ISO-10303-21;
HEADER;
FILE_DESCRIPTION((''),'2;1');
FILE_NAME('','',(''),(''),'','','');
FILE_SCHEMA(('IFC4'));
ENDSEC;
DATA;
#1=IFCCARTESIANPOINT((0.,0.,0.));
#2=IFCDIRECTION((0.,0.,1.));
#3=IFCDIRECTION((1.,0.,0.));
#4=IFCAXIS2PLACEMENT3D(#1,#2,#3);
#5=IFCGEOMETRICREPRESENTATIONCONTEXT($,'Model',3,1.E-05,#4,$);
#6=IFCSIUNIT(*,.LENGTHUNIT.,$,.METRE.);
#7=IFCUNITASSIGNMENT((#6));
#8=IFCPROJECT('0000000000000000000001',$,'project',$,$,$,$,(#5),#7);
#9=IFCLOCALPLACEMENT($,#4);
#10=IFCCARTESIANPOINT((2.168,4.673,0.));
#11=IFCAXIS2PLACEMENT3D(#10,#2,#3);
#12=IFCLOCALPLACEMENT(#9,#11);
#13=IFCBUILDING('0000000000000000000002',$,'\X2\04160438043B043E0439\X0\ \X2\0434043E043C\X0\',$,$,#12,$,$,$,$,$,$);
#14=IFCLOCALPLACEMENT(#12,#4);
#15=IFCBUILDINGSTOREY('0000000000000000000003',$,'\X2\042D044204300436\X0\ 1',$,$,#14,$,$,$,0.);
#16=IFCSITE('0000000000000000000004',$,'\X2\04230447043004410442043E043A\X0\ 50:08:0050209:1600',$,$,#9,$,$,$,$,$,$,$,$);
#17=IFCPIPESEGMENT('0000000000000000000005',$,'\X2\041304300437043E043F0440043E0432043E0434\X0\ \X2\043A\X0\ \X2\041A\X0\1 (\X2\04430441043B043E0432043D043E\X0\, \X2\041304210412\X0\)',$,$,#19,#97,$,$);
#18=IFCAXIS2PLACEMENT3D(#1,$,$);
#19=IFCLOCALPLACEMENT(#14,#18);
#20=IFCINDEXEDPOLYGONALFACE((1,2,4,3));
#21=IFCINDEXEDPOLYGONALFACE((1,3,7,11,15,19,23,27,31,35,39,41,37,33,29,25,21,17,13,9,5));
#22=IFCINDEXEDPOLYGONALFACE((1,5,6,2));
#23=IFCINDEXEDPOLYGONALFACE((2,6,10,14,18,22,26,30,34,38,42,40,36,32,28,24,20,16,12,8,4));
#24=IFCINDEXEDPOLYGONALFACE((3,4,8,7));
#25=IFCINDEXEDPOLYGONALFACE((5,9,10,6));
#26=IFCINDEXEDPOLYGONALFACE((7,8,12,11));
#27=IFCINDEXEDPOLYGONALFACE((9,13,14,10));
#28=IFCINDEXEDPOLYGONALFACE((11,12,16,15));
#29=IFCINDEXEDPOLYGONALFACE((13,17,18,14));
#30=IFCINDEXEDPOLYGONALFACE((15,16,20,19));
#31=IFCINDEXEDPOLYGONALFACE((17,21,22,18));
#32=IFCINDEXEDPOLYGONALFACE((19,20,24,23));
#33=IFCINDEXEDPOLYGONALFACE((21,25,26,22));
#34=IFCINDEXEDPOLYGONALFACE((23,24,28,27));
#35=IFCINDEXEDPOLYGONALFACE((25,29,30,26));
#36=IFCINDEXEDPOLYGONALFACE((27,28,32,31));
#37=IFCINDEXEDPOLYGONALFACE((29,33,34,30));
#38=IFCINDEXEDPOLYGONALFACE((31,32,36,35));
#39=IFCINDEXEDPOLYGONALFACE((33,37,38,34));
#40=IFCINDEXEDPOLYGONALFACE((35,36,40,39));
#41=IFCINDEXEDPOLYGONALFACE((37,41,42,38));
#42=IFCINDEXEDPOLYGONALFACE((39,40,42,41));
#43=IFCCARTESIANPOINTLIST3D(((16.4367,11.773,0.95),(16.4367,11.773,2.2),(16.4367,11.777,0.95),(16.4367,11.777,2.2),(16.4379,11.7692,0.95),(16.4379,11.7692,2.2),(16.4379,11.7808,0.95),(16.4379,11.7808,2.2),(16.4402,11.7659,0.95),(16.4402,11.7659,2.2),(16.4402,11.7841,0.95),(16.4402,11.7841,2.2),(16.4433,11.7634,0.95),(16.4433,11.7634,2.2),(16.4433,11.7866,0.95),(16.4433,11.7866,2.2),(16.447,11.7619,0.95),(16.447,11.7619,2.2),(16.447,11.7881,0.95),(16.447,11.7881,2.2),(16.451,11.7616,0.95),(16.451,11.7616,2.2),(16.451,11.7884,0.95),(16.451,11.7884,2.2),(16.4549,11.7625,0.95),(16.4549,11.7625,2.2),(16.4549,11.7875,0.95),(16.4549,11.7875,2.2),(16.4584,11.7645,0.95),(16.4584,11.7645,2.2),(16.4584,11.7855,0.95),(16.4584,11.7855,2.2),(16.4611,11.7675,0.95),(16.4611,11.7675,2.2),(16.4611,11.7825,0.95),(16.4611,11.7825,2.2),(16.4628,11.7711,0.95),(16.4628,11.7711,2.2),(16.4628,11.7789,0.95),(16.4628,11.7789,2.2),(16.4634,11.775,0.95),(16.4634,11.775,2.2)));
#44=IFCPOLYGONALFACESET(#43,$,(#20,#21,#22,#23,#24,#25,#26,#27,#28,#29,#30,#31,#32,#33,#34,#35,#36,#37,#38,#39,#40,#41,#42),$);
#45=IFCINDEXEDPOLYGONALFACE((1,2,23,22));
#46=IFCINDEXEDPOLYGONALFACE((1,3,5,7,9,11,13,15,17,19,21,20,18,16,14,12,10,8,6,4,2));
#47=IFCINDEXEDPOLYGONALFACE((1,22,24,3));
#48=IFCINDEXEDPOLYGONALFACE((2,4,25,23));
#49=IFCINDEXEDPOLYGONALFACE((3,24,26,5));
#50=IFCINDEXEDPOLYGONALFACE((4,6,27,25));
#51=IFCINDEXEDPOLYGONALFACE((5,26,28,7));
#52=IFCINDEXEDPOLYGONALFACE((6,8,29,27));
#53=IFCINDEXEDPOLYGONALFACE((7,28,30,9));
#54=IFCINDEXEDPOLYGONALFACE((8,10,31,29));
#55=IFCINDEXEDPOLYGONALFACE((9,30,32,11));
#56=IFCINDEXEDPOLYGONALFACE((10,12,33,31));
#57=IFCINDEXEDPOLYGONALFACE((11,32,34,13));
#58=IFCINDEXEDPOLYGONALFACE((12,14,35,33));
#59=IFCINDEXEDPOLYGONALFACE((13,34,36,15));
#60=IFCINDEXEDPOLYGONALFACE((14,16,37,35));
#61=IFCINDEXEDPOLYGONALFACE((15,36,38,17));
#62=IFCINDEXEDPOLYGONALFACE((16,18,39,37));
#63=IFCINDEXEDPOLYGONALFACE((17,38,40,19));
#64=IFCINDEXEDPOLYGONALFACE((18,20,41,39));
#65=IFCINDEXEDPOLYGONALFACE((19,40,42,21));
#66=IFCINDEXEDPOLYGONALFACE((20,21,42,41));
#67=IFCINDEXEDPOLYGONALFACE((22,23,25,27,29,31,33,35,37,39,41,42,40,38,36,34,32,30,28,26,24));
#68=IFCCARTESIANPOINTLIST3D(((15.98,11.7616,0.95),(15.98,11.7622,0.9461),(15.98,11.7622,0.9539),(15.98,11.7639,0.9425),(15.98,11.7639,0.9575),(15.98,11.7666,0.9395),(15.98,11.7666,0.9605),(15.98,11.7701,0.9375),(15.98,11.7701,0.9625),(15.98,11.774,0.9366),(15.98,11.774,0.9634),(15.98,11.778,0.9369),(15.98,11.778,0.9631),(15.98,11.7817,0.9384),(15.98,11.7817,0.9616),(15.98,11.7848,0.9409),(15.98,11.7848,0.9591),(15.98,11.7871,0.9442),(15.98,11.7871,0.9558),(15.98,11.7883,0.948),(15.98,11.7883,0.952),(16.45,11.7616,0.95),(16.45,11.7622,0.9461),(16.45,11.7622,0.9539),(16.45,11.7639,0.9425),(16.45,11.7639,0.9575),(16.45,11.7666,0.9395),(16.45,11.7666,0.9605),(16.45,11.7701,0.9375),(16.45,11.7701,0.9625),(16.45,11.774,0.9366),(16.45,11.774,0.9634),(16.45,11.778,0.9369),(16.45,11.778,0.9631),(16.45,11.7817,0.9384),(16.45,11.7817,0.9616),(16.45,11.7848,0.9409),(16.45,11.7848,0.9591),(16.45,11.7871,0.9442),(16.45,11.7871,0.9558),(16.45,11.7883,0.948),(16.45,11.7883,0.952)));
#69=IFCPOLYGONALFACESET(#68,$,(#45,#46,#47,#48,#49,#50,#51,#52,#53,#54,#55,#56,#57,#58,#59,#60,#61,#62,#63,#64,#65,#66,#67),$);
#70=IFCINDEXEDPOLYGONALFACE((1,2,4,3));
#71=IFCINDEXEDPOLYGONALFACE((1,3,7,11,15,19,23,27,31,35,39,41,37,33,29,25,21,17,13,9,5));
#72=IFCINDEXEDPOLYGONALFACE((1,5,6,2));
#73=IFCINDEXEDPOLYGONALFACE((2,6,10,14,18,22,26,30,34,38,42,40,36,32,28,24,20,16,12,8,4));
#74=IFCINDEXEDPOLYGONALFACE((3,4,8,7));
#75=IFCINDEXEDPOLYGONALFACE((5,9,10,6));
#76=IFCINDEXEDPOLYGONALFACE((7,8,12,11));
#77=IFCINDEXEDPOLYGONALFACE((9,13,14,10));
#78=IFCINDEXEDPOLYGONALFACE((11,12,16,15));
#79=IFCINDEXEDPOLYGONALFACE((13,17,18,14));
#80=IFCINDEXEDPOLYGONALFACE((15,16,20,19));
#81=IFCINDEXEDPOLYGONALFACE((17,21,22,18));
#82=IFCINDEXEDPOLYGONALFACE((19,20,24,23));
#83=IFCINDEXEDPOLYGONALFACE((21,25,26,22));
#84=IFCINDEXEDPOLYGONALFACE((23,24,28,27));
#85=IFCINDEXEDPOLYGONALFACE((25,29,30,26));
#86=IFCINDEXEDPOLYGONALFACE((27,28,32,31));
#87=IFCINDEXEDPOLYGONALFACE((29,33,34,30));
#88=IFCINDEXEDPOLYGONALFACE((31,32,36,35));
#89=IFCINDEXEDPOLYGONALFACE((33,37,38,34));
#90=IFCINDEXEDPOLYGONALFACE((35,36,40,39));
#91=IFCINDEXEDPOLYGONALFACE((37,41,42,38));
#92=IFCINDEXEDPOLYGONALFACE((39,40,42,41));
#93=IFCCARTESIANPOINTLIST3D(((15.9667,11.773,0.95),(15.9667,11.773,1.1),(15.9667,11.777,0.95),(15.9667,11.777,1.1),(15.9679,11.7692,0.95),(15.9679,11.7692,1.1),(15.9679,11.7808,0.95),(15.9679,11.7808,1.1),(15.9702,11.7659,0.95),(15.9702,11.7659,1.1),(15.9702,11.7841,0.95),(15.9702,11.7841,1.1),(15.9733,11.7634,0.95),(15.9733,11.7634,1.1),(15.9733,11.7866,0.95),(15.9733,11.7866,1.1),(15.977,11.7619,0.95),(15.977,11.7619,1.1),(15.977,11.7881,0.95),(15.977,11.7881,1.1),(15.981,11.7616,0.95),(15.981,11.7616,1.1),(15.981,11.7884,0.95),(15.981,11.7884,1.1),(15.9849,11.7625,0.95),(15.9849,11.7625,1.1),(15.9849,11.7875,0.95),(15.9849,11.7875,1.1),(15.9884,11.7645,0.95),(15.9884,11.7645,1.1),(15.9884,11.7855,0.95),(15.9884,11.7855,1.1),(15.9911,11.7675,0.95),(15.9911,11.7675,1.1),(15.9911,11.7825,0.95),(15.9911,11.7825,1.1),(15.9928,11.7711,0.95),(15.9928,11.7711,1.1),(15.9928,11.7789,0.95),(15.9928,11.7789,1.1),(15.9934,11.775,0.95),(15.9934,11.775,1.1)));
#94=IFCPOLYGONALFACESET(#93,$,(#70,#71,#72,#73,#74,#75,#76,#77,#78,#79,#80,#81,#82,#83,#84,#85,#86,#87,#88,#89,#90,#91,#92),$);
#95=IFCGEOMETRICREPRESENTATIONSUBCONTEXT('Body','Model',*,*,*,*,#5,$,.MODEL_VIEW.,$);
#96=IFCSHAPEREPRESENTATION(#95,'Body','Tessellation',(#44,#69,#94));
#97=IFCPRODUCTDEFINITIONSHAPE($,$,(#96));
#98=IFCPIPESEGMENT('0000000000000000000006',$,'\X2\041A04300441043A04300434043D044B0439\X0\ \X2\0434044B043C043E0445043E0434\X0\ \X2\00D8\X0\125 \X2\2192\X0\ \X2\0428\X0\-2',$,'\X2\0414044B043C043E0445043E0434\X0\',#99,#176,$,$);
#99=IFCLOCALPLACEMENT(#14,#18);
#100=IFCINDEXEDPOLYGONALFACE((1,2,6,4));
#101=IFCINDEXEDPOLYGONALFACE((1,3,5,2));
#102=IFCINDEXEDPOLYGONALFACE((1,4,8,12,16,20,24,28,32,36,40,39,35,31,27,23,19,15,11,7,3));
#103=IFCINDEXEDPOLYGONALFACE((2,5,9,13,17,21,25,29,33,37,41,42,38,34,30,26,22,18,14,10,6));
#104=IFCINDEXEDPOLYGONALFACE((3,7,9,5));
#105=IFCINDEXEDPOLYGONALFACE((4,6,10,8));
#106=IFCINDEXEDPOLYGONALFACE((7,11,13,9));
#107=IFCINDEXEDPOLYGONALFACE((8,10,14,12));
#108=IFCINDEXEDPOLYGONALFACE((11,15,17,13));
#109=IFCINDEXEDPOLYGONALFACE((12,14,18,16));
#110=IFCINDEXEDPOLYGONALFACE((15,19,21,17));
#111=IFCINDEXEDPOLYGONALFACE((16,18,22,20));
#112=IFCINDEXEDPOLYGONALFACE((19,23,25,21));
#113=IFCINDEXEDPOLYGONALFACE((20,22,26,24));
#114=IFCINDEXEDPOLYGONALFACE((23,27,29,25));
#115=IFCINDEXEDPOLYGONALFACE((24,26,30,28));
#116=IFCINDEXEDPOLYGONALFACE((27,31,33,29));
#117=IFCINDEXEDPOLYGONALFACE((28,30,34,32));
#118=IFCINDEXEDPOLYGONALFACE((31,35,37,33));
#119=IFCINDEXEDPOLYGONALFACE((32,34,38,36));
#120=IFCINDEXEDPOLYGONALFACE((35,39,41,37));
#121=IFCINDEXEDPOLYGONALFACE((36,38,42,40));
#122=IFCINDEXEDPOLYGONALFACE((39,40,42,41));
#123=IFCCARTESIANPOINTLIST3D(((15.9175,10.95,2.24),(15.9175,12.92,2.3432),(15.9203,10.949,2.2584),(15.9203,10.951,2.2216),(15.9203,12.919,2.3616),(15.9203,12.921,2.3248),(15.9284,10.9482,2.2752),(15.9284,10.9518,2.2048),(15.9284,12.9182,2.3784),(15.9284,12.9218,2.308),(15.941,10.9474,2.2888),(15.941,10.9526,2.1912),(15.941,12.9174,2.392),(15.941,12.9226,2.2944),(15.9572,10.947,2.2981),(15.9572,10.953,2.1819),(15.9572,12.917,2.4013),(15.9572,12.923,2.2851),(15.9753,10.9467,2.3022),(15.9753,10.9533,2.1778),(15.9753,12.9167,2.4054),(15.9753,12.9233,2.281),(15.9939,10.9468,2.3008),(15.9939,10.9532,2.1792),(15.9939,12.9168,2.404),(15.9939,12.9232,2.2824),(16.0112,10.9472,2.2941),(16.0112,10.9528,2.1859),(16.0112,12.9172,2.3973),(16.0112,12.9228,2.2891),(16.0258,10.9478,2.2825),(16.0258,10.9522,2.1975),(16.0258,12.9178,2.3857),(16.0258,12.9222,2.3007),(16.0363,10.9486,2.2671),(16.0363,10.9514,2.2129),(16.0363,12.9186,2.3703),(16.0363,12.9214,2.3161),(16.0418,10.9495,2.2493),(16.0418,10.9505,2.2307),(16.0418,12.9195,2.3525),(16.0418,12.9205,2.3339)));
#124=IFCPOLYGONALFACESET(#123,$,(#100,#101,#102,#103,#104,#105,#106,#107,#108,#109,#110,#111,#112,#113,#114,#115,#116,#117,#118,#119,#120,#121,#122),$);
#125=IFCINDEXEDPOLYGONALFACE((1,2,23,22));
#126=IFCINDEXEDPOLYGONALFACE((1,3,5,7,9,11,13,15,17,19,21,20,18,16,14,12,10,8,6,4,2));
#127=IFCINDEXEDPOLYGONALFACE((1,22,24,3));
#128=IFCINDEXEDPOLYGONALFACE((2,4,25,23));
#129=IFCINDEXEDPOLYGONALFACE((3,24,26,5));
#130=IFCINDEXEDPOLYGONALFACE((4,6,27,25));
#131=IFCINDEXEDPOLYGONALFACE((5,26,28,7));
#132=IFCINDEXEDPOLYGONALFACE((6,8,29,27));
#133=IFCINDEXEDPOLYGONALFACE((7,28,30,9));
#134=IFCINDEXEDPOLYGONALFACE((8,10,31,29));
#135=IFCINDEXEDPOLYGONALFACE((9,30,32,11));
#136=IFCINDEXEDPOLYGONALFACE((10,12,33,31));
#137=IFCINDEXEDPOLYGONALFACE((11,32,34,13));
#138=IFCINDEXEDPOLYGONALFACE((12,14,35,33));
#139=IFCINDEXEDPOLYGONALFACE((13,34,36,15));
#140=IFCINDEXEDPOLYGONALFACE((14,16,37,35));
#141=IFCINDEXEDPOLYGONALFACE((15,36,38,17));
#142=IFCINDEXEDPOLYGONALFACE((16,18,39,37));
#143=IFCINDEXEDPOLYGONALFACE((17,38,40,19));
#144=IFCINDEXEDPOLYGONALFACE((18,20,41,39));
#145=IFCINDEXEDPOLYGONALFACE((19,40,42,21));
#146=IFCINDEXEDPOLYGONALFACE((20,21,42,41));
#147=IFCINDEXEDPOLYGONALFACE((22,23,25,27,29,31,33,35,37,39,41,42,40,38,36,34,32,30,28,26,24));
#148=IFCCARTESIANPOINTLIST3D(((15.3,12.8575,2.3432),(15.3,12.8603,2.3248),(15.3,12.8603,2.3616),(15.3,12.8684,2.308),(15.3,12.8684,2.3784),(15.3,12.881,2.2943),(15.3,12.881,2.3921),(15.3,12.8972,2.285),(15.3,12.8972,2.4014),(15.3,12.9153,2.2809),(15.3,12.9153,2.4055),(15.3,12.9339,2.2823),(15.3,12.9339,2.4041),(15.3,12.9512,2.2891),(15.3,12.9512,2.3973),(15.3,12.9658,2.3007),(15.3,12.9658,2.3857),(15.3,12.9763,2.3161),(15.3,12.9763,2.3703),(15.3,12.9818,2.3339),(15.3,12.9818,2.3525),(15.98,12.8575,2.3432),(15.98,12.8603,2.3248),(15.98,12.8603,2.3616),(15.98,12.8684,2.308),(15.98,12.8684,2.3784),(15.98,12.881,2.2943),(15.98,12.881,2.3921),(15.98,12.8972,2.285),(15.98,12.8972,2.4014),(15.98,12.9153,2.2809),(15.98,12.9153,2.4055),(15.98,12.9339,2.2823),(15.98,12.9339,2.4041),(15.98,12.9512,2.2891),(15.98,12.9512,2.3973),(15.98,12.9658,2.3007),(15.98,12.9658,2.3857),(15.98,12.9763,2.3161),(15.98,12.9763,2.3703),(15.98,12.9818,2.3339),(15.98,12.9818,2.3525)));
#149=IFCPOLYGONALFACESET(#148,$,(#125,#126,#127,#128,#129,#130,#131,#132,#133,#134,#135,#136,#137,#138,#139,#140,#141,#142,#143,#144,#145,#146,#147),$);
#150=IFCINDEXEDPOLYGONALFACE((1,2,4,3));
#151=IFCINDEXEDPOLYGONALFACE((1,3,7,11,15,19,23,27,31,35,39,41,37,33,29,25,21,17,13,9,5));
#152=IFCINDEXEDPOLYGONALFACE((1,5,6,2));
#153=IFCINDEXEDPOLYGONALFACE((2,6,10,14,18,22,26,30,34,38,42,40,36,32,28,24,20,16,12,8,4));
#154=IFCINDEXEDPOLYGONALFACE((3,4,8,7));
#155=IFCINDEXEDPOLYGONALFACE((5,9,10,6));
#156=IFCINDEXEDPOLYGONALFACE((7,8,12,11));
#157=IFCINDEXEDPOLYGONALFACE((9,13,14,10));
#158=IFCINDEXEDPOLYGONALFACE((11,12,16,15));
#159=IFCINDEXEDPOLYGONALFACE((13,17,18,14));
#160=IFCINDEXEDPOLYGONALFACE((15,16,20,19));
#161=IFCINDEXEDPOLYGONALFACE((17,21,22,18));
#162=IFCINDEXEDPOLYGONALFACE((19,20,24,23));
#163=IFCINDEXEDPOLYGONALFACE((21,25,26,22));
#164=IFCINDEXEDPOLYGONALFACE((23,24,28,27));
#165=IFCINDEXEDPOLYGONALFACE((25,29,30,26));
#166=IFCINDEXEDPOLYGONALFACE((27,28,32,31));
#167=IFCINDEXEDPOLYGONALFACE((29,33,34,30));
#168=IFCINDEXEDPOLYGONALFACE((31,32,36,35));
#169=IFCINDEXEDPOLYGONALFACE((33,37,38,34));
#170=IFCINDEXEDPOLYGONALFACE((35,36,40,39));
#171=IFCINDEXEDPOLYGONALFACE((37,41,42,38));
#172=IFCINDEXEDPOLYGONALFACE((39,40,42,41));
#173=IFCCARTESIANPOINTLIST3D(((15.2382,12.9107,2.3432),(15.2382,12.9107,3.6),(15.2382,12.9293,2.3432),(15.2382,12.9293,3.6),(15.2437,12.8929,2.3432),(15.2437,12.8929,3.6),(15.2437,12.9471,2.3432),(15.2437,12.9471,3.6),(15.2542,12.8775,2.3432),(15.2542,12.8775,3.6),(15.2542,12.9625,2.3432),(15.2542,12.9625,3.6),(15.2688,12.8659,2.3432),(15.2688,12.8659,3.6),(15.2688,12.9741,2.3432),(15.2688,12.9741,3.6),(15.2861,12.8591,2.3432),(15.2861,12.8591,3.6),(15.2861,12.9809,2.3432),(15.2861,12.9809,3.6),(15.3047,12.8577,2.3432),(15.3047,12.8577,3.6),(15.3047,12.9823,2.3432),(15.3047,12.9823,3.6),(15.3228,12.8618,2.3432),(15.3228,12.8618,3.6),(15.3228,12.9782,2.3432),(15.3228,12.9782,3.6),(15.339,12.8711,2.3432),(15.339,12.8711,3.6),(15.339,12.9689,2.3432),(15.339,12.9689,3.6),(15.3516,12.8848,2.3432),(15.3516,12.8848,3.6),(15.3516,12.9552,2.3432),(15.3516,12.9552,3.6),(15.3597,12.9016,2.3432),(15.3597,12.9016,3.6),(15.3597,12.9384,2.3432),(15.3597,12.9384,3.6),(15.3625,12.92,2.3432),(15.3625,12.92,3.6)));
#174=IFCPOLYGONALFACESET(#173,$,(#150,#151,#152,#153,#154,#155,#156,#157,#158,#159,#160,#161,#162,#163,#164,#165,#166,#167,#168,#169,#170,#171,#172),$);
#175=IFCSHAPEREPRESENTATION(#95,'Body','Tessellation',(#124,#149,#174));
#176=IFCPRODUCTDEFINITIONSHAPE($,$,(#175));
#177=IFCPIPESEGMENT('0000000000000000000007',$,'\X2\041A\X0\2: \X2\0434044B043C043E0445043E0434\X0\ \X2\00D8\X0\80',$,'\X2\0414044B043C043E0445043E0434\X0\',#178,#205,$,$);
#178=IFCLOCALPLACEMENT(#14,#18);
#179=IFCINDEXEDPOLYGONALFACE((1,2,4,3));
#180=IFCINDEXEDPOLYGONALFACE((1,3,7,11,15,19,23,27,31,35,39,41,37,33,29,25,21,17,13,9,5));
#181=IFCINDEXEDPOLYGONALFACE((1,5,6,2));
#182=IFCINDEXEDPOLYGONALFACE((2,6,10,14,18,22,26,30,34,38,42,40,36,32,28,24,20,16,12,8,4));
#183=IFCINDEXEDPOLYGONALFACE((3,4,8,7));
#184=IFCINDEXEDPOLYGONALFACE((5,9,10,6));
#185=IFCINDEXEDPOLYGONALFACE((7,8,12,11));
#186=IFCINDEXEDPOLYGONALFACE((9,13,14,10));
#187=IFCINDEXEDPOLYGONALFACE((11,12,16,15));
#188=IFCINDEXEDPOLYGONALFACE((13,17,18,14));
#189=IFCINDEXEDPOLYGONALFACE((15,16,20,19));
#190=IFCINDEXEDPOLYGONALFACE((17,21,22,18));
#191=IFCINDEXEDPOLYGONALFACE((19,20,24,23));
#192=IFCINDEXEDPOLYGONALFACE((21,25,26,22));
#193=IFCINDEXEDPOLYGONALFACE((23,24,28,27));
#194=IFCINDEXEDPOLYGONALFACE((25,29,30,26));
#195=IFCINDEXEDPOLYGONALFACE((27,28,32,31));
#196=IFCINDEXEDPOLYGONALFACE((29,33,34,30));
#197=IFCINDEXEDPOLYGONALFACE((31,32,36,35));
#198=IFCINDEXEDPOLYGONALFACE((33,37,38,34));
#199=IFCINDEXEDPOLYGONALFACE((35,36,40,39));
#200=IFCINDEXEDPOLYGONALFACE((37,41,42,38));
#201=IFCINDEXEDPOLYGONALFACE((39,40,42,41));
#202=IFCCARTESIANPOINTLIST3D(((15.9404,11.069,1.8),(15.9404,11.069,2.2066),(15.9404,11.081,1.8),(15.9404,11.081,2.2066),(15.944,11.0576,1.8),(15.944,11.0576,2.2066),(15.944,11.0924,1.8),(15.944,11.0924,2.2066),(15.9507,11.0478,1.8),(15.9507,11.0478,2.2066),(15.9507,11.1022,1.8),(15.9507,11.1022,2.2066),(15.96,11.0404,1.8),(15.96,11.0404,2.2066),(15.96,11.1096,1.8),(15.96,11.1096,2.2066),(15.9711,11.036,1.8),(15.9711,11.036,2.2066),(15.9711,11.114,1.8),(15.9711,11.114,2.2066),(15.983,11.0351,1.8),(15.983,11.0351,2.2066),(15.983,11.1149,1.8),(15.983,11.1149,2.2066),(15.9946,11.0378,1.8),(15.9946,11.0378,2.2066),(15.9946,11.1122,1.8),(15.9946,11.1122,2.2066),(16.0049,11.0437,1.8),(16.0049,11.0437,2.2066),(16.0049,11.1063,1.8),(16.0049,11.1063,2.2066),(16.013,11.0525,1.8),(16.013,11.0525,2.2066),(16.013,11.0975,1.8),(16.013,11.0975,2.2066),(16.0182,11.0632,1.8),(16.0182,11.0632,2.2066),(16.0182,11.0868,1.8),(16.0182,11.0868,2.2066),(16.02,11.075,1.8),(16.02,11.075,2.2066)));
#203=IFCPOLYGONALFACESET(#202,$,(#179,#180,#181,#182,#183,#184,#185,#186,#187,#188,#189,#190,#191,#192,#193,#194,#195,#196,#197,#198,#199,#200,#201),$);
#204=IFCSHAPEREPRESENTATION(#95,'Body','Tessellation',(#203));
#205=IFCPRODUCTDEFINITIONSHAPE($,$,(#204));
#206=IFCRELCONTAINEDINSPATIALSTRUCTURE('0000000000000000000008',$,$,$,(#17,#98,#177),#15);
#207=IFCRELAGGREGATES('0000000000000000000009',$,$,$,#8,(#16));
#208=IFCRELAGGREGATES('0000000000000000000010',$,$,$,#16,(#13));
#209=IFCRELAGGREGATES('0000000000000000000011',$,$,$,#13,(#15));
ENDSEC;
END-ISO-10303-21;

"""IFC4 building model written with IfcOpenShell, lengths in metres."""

from ifc_helpers import new_model, si_unit, frame, origin_with_axes, origin_2d, place, context, subcontext, project, spatial, circle, extrude, element, save


model = new_model("IFC4")

# Units and contexts
model_context = context("Model", 3, precision=1e-05, world=origin_with_axes())
body_context = subcontext(model_context, "Body", "Model", "MODEL_VIEW")
ifc_project = project(units=[si_unit("LENGTHUNIT", "METRE")], contexts=[model_context])

# Site, building, storey
site_placement = place(None, origin_with_axes())
site = spatial("IfcSite", under=ifc_project, at=site_placement, Name="Участок 50:08:0050209:1600")
building_placement = place(site_placement, frame((2.168, 4.673, 0.0), z_axis=(0.0, 0.0, 1.0), x_axis=(1.0, 0.0, 0.0)))
building = spatial("IfcBuilding", under=site, at=building_placement, Name="Жилой дом")
storey_placement = place(building_placement, origin_with_axes())
storey = spatial("IfcBuildingStorey", under=building, at=storey_placement, Name="Этаж 1", Elevation=0.0)

# Pipe segments
pipe_segment_1_placement = place(storey_placement, origin_with_axes())
element("IfcPipeSegment", 1, at=pipe_segment_1_placement, inside=storey, Name="Газопровод к К1 (условно, ГСВ)", context=body_context, shape_type="SweptSolid", body=[
    extrude(circle(Radius=0.0134, at=origin_2d()), frame((16.45, 11.775, 2.2), z_axis=(0.0, 0.0, -1.0), x_axis=(1.0, 0.0, 0.0)), (0.0, 0.0, 1.0), 1.25),
    extrude(circle(Radius=0.0134, at=origin_2d()), frame((16.45, 11.775, 0.95), z_axis=(-1.0, 0.0, 0.0), x_axis=(0.0, -1.0, 0.0)), (0.0, 0.0, 1.0), 0.47),
    extrude(circle(Radius=0.0134, at=origin_2d()), frame((15.98, 11.775, 0.95), z_axis=(0.0, 0.0, 1.0), x_axis=(1.0, 0.0, 0.0)), (0.0, 0.0, 1.0), 0.15),
])
pipe_segment_2_placement = place(storey_placement, origin_with_axes())
element("IfcPipeSegment", 2, at=pipe_segment_2_placement, inside=storey, Name="Каскадный дымоход Ø125 → Ш-2", ObjectType="Дымоход", context=body_context, shape_type="SweptSolid", body=[
    extrude(circle(Radius=0.0625, at=origin_2d()), frame((15.98, 10.95, 2.24), z_axis=(0.0, 0.998631, 0.052314), x_axis=(-1.0, 0.0, 0.0)), (0.0, 0.0, 1.0), 1.9727),
    extrude(circle(Radius=0.0625, at=origin_2d()), frame((15.98, 12.92, 2.3432), z_axis=(-1.0, 0.0, 0.0), x_axis=(0.0, -1.0, 0.0)), (0.0, 0.0, 1.0), 0.68),
    extrude(circle(Radius=0.0625, at=origin_2d()), frame((15.3, 12.92, 2.3432), z_axis=(0.0, 0.0, 1.0), x_axis=(1.0, 0.0, 0.0)), (0.0, 0.0, 1.0), 1.2568),
])
pipe_segment_3_placement = place(storey_placement, origin_with_axes())
element("IfcPipeSegment", 3, at=pipe_segment_3_placement, inside=storey, Name="К2: дымоход Ø80", ObjectType="Дымоход", context=body_context, shape_type="SweptSolid", body=[
    extrude(circle(Radius=0.04, at=origin_2d()), frame((15.98, 11.075, 1.8), z_axis=(0.0, 0.0, 1.0), x_axis=(1.0, 0.0, 0.0)), (0.0, 0.0, 1.0), 0.4066),
])

save(model, "model.ifc")
